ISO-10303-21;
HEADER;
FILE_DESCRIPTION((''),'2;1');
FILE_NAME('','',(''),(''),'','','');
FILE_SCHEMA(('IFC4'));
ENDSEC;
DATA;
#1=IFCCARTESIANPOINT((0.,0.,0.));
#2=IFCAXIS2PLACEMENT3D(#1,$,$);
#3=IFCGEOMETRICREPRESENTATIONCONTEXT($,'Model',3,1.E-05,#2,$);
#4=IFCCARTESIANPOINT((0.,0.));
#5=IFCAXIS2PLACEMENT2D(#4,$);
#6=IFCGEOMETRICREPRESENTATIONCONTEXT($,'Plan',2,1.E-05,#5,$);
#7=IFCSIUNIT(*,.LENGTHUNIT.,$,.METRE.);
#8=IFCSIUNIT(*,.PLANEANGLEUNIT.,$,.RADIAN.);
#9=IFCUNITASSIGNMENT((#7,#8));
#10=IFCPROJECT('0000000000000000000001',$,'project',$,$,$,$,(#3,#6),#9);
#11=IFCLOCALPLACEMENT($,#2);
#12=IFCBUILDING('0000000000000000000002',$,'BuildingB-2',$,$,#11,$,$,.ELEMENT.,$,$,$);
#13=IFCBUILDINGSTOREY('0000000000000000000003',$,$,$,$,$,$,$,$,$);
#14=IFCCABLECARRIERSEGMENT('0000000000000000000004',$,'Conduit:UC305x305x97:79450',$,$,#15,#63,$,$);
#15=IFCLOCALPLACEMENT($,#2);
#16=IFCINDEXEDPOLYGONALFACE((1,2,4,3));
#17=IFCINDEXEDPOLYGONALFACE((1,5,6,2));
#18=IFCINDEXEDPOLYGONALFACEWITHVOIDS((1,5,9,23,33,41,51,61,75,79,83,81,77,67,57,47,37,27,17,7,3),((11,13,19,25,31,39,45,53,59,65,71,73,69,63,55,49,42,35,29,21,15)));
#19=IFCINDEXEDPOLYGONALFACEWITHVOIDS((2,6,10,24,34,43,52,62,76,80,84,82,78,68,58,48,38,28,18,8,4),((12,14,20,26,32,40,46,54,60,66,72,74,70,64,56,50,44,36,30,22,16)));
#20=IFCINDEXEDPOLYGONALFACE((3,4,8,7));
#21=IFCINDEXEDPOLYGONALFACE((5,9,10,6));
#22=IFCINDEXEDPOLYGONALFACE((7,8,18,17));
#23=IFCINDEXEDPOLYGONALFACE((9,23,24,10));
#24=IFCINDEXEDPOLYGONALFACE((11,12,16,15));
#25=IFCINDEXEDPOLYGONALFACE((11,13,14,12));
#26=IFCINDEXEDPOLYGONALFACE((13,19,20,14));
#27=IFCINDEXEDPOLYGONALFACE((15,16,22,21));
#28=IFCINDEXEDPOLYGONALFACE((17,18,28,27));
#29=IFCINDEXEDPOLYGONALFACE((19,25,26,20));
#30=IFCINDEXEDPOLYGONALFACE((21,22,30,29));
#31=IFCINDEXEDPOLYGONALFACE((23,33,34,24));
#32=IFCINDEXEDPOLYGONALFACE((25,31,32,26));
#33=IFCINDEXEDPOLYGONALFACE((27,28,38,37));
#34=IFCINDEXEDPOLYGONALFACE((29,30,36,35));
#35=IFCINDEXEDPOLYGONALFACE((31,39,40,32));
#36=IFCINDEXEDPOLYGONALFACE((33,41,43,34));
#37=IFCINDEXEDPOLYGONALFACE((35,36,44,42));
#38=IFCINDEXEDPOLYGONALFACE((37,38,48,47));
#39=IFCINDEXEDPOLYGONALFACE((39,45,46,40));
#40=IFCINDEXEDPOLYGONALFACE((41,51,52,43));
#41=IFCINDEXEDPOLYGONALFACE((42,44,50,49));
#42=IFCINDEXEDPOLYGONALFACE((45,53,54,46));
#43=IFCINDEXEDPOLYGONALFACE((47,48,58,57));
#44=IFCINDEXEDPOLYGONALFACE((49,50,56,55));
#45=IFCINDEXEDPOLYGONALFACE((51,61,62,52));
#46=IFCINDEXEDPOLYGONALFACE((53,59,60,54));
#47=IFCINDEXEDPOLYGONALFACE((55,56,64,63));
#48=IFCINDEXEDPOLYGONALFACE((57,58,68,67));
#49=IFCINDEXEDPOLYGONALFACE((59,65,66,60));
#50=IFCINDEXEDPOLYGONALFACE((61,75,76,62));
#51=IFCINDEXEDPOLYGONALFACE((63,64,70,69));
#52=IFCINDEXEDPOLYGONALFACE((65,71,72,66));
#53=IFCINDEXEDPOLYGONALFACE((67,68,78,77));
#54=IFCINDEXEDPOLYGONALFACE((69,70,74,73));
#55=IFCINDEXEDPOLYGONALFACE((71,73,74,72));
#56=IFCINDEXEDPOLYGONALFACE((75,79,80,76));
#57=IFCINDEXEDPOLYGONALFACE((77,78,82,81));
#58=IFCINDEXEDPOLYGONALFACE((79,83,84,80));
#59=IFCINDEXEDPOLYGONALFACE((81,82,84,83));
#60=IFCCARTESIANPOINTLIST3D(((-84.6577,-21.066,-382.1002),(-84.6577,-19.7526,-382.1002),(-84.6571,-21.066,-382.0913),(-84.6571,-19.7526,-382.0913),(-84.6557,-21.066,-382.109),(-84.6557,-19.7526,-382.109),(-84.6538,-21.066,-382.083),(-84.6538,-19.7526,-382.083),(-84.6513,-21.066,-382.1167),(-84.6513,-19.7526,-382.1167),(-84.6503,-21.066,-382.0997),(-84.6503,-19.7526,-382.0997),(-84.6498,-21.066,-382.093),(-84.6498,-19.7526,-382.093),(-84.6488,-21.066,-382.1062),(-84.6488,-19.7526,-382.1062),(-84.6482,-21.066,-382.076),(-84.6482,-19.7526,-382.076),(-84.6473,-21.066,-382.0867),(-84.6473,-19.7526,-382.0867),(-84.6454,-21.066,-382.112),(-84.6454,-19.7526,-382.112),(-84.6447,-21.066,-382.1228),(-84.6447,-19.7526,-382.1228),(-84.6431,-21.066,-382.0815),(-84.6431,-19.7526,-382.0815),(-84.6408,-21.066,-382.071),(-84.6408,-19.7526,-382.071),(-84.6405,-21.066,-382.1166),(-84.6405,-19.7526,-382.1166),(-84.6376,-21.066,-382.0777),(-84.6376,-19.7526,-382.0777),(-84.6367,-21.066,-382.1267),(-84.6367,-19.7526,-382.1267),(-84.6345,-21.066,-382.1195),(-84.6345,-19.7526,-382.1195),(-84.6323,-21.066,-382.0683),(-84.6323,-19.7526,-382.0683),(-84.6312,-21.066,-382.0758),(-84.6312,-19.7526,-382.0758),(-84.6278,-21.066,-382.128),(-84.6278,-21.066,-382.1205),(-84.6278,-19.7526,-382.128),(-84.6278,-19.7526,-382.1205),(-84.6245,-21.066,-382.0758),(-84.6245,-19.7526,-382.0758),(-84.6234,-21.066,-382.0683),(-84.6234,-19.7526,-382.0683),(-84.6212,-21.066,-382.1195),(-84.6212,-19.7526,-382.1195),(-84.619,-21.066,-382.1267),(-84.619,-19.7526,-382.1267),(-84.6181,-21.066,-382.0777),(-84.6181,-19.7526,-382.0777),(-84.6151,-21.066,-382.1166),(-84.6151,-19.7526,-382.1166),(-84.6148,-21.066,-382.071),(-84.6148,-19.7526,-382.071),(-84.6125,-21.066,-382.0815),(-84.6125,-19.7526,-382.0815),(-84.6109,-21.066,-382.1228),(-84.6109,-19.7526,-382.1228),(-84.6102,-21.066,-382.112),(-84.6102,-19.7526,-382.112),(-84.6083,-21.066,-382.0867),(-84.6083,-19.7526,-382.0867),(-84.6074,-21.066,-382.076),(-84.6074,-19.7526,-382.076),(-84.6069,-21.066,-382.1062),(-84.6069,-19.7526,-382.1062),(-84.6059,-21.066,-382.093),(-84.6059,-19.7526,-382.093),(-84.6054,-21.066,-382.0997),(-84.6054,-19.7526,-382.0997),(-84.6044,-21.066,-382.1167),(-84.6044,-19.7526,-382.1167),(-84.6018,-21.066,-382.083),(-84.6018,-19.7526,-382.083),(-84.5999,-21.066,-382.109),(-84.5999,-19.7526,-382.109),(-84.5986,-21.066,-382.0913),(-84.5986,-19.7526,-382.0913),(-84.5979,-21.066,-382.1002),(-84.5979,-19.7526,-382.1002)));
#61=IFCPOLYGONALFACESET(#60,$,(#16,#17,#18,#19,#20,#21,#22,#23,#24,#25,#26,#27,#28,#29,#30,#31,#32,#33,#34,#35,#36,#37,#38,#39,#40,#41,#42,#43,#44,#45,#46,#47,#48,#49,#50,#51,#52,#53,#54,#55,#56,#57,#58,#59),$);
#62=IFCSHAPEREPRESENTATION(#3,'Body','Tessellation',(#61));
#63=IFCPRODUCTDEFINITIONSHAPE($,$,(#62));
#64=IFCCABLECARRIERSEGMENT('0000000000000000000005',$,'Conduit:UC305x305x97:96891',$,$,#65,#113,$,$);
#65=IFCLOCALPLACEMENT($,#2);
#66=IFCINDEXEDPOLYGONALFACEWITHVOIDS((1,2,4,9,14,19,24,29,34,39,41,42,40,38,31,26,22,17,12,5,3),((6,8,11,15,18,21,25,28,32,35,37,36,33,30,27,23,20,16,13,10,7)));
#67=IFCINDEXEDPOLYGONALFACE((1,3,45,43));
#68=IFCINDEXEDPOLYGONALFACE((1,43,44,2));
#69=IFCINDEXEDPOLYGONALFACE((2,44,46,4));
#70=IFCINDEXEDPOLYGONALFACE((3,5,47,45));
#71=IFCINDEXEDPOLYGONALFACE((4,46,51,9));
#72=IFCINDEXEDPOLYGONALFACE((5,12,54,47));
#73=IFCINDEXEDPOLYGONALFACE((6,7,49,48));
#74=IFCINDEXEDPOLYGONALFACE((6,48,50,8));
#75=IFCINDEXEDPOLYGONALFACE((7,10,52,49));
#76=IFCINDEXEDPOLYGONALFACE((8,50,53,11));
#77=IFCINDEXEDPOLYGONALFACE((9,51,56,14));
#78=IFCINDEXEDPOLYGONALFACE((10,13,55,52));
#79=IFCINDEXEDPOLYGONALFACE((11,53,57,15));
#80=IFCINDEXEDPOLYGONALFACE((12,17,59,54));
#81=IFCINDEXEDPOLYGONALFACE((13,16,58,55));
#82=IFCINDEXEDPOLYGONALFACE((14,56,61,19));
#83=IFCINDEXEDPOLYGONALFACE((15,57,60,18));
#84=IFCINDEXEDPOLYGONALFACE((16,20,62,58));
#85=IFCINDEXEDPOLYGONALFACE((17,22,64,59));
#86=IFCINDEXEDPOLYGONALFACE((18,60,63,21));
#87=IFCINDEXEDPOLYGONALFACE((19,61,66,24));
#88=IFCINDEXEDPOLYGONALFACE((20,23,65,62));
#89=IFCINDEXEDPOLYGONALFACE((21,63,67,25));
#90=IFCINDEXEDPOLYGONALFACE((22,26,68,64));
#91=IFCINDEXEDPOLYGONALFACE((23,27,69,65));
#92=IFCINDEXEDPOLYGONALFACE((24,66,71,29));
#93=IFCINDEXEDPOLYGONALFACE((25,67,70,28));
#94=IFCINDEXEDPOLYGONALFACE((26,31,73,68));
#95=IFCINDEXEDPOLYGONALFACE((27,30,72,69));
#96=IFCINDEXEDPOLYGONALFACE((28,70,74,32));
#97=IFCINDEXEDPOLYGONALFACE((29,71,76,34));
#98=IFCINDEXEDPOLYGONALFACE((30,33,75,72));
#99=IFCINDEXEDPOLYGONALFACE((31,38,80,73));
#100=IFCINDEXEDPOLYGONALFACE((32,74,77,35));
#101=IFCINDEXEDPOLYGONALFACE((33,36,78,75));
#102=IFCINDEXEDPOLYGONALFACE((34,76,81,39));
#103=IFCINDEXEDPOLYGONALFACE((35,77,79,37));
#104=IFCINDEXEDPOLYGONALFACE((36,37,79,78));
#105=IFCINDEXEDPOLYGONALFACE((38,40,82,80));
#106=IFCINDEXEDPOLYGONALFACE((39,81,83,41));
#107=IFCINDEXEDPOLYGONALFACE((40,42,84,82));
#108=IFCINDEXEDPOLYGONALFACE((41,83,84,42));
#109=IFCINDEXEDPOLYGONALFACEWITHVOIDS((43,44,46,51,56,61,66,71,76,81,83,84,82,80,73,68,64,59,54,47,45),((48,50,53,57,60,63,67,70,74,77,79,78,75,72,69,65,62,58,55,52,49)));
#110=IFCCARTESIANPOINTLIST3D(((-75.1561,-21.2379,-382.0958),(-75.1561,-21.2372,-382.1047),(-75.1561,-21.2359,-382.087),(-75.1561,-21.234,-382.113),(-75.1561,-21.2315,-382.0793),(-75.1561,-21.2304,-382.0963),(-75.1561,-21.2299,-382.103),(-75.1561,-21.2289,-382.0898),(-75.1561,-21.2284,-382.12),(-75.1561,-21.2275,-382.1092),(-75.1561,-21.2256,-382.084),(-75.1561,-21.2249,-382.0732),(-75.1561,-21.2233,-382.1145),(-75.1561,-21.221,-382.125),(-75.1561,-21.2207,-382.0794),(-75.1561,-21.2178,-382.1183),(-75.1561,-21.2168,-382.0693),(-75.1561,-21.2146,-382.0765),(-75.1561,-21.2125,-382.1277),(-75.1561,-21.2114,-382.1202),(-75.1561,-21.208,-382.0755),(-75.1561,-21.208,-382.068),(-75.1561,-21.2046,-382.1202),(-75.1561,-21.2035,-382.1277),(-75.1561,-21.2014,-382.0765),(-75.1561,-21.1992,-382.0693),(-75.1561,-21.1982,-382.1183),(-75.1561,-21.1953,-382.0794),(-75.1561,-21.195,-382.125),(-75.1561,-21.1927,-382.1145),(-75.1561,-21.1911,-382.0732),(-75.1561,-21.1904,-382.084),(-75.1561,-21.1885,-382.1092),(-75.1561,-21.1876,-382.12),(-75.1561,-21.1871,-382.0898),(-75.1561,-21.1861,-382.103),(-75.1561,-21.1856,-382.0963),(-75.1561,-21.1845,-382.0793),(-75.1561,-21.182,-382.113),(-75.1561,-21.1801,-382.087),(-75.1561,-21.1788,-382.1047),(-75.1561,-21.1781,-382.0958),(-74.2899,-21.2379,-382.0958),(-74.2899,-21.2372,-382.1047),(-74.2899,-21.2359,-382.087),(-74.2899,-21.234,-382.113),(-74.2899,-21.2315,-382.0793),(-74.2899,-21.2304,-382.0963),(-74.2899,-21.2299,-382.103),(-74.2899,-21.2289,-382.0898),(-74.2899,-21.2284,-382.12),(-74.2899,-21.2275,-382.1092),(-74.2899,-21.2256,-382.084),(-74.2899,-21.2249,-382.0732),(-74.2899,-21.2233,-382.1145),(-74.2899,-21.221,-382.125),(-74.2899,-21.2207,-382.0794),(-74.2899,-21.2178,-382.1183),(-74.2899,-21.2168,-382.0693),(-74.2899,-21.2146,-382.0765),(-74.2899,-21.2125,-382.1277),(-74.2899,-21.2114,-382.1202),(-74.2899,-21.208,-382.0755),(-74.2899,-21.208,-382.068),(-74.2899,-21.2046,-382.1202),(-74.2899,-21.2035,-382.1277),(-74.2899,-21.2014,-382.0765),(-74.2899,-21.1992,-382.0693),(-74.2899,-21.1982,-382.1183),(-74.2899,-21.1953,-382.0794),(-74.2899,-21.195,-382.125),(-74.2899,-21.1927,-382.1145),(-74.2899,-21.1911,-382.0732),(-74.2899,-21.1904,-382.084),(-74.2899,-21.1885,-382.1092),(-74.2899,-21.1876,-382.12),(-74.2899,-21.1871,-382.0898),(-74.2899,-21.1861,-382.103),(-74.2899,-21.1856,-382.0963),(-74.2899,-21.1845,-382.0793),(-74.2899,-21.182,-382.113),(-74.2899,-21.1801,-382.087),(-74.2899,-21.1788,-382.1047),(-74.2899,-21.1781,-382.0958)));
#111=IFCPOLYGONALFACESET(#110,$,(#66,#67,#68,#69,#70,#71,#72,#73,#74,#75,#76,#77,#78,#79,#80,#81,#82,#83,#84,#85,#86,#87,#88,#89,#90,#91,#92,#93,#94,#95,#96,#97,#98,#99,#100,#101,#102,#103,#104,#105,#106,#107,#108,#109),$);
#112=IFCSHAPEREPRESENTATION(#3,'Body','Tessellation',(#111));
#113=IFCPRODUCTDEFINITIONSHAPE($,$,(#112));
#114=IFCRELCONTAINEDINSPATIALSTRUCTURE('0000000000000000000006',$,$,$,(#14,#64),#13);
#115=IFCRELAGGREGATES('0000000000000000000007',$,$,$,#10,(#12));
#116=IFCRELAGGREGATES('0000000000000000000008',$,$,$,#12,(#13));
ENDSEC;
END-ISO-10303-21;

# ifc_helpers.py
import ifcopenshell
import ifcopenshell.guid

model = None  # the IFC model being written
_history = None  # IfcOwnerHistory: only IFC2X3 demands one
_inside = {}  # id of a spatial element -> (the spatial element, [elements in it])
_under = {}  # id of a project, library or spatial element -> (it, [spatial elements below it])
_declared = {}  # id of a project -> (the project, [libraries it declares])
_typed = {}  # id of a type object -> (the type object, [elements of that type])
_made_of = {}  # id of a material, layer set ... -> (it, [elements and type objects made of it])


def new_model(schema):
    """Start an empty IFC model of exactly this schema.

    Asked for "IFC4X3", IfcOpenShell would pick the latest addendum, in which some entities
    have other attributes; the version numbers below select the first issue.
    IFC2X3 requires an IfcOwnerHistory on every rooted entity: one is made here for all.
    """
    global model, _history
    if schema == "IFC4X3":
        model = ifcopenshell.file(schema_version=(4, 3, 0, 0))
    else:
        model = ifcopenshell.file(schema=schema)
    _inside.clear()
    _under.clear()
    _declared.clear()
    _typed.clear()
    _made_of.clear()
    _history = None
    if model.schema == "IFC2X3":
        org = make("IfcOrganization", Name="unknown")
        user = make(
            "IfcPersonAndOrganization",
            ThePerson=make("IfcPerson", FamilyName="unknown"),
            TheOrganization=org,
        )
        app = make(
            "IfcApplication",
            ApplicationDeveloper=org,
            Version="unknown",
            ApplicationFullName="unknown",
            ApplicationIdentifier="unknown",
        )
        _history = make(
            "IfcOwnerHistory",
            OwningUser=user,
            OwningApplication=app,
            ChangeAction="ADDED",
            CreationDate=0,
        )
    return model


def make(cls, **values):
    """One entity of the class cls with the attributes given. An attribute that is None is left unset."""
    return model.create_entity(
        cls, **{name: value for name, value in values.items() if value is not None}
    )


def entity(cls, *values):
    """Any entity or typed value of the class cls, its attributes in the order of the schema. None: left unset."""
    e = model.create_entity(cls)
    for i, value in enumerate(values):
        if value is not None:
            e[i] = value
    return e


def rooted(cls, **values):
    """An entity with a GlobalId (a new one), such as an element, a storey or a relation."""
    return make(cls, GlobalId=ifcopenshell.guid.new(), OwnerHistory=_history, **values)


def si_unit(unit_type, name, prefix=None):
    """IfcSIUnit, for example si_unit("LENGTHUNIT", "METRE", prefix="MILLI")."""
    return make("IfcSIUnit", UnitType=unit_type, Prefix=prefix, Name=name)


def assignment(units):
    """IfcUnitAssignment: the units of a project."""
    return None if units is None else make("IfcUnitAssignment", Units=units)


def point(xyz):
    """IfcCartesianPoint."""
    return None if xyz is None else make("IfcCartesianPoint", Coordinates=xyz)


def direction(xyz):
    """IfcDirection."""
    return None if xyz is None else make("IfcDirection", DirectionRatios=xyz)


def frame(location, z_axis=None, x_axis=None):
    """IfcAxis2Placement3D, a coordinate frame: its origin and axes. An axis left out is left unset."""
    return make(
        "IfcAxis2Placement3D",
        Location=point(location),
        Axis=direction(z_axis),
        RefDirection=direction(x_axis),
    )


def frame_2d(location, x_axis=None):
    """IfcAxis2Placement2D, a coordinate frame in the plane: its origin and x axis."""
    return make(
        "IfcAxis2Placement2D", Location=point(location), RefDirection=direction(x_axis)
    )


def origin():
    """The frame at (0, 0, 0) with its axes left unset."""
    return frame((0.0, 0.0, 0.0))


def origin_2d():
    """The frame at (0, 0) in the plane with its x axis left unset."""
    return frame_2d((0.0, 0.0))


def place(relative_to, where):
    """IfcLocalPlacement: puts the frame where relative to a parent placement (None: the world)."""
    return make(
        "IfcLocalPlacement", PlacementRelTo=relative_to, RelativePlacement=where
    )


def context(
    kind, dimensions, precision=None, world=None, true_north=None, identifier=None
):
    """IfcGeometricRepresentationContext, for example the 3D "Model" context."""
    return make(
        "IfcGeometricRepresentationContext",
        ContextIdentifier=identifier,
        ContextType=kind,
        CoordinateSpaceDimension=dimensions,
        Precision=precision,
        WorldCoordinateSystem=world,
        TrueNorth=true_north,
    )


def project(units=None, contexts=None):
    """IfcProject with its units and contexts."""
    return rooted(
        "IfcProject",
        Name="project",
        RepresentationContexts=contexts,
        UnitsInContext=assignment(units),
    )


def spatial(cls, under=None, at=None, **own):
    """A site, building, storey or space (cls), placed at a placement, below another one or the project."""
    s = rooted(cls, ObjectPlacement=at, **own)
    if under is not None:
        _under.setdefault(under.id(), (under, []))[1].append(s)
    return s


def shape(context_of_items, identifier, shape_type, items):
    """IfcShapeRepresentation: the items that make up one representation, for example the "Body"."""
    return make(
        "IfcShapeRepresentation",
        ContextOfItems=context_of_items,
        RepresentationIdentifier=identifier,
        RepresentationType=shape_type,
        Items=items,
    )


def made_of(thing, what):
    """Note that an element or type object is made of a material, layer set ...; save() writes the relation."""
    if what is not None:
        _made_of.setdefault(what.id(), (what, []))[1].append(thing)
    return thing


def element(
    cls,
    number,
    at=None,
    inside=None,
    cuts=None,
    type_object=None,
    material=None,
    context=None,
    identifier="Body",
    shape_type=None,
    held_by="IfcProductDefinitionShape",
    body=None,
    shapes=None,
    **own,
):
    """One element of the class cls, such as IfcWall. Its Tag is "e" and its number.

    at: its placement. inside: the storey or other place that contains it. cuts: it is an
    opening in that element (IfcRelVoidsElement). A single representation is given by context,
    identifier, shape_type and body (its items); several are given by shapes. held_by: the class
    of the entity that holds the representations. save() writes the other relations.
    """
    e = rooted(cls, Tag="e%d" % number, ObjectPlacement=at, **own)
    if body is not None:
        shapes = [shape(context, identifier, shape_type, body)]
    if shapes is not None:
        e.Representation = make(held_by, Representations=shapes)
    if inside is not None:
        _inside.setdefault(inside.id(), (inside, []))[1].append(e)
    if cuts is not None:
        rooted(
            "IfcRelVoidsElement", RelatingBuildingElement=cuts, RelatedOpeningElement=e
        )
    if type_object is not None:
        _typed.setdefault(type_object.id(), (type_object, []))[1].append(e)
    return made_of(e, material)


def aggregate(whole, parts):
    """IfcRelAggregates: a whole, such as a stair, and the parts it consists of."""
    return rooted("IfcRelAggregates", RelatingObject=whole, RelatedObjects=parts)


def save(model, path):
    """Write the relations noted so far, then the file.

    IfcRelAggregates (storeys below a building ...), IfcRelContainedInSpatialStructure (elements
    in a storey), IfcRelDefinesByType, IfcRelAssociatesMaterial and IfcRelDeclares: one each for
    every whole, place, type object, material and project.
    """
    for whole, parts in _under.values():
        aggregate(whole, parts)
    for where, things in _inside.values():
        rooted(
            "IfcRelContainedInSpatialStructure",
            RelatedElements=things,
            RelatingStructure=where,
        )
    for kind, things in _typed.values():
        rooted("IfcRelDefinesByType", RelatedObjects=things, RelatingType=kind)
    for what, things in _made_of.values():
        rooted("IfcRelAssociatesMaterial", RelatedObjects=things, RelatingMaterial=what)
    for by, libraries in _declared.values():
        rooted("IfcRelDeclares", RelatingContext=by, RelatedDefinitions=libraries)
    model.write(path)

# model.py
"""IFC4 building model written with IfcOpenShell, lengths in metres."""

from ifc_helpers import new_model, entity, si_unit, origin, origin_2d, place, context, project, spatial, element, save


model = new_model("IFC4")

# Units and contexts
model_context = context("Model", 3, precision=1e-05, world=origin())
plan_context = context("Plan", 2, precision=1e-05, world=origin_2d())
ifc_project = project(units=[si_unit("LENGTHUNIT", "METRE"), si_unit("PLANEANGLEUNIT", "RADIAN")], contexts=[model_context, plan_context])

# Building, storey
building_placement = place(None, origin())
building = spatial("IfcBuilding", under=ifc_project, at=building_placement, Name="BuildingB-2", CompositionType="ELEMENT")
storey = spatial("IfcBuildingStorey", under=building)

# Cable carrier segments
element("IfcCableCarrierSegment", 1, inside=storey, Name="Conduit:UC305x305x97:79450", context=model_context, shape_type="AdvancedSweptSolid", body=[
    entity("IfcSweptDiskSolid", entity("IfcCompositeCurve", [entity("IfcCompositeCurveSegment", "CONTINUOUS", False, entity("IfcPolyline", [entity("IfcCartesianPoint", [84.6278, 21.066, 382.098]), entity("IfcCartesianPoint", [84.6278, 19.7526, 382.098])]))], False), 0.03, 0.0225),
])
element("IfcCableCarrierSegment", 2, inside=storey, Name="Conduit:UC305x305x97:96891", context=model_context, shape_type="AdvancedSweptSolid", body=[
    entity("IfcSweptDiskSolid", entity("IfcCompositeCurve", [entity("IfcCompositeCurveSegment", "CONTINUOUS", False, entity("IfcPolyline", [entity("IfcCartesianPoint", [74.2899, 21.208, 382.098]), entity("IfcCartesianPoint", [75.1561, 21.208, 382.098])]))], False), 0.03, 0.0225),
])

save(model, "model.ifc")
